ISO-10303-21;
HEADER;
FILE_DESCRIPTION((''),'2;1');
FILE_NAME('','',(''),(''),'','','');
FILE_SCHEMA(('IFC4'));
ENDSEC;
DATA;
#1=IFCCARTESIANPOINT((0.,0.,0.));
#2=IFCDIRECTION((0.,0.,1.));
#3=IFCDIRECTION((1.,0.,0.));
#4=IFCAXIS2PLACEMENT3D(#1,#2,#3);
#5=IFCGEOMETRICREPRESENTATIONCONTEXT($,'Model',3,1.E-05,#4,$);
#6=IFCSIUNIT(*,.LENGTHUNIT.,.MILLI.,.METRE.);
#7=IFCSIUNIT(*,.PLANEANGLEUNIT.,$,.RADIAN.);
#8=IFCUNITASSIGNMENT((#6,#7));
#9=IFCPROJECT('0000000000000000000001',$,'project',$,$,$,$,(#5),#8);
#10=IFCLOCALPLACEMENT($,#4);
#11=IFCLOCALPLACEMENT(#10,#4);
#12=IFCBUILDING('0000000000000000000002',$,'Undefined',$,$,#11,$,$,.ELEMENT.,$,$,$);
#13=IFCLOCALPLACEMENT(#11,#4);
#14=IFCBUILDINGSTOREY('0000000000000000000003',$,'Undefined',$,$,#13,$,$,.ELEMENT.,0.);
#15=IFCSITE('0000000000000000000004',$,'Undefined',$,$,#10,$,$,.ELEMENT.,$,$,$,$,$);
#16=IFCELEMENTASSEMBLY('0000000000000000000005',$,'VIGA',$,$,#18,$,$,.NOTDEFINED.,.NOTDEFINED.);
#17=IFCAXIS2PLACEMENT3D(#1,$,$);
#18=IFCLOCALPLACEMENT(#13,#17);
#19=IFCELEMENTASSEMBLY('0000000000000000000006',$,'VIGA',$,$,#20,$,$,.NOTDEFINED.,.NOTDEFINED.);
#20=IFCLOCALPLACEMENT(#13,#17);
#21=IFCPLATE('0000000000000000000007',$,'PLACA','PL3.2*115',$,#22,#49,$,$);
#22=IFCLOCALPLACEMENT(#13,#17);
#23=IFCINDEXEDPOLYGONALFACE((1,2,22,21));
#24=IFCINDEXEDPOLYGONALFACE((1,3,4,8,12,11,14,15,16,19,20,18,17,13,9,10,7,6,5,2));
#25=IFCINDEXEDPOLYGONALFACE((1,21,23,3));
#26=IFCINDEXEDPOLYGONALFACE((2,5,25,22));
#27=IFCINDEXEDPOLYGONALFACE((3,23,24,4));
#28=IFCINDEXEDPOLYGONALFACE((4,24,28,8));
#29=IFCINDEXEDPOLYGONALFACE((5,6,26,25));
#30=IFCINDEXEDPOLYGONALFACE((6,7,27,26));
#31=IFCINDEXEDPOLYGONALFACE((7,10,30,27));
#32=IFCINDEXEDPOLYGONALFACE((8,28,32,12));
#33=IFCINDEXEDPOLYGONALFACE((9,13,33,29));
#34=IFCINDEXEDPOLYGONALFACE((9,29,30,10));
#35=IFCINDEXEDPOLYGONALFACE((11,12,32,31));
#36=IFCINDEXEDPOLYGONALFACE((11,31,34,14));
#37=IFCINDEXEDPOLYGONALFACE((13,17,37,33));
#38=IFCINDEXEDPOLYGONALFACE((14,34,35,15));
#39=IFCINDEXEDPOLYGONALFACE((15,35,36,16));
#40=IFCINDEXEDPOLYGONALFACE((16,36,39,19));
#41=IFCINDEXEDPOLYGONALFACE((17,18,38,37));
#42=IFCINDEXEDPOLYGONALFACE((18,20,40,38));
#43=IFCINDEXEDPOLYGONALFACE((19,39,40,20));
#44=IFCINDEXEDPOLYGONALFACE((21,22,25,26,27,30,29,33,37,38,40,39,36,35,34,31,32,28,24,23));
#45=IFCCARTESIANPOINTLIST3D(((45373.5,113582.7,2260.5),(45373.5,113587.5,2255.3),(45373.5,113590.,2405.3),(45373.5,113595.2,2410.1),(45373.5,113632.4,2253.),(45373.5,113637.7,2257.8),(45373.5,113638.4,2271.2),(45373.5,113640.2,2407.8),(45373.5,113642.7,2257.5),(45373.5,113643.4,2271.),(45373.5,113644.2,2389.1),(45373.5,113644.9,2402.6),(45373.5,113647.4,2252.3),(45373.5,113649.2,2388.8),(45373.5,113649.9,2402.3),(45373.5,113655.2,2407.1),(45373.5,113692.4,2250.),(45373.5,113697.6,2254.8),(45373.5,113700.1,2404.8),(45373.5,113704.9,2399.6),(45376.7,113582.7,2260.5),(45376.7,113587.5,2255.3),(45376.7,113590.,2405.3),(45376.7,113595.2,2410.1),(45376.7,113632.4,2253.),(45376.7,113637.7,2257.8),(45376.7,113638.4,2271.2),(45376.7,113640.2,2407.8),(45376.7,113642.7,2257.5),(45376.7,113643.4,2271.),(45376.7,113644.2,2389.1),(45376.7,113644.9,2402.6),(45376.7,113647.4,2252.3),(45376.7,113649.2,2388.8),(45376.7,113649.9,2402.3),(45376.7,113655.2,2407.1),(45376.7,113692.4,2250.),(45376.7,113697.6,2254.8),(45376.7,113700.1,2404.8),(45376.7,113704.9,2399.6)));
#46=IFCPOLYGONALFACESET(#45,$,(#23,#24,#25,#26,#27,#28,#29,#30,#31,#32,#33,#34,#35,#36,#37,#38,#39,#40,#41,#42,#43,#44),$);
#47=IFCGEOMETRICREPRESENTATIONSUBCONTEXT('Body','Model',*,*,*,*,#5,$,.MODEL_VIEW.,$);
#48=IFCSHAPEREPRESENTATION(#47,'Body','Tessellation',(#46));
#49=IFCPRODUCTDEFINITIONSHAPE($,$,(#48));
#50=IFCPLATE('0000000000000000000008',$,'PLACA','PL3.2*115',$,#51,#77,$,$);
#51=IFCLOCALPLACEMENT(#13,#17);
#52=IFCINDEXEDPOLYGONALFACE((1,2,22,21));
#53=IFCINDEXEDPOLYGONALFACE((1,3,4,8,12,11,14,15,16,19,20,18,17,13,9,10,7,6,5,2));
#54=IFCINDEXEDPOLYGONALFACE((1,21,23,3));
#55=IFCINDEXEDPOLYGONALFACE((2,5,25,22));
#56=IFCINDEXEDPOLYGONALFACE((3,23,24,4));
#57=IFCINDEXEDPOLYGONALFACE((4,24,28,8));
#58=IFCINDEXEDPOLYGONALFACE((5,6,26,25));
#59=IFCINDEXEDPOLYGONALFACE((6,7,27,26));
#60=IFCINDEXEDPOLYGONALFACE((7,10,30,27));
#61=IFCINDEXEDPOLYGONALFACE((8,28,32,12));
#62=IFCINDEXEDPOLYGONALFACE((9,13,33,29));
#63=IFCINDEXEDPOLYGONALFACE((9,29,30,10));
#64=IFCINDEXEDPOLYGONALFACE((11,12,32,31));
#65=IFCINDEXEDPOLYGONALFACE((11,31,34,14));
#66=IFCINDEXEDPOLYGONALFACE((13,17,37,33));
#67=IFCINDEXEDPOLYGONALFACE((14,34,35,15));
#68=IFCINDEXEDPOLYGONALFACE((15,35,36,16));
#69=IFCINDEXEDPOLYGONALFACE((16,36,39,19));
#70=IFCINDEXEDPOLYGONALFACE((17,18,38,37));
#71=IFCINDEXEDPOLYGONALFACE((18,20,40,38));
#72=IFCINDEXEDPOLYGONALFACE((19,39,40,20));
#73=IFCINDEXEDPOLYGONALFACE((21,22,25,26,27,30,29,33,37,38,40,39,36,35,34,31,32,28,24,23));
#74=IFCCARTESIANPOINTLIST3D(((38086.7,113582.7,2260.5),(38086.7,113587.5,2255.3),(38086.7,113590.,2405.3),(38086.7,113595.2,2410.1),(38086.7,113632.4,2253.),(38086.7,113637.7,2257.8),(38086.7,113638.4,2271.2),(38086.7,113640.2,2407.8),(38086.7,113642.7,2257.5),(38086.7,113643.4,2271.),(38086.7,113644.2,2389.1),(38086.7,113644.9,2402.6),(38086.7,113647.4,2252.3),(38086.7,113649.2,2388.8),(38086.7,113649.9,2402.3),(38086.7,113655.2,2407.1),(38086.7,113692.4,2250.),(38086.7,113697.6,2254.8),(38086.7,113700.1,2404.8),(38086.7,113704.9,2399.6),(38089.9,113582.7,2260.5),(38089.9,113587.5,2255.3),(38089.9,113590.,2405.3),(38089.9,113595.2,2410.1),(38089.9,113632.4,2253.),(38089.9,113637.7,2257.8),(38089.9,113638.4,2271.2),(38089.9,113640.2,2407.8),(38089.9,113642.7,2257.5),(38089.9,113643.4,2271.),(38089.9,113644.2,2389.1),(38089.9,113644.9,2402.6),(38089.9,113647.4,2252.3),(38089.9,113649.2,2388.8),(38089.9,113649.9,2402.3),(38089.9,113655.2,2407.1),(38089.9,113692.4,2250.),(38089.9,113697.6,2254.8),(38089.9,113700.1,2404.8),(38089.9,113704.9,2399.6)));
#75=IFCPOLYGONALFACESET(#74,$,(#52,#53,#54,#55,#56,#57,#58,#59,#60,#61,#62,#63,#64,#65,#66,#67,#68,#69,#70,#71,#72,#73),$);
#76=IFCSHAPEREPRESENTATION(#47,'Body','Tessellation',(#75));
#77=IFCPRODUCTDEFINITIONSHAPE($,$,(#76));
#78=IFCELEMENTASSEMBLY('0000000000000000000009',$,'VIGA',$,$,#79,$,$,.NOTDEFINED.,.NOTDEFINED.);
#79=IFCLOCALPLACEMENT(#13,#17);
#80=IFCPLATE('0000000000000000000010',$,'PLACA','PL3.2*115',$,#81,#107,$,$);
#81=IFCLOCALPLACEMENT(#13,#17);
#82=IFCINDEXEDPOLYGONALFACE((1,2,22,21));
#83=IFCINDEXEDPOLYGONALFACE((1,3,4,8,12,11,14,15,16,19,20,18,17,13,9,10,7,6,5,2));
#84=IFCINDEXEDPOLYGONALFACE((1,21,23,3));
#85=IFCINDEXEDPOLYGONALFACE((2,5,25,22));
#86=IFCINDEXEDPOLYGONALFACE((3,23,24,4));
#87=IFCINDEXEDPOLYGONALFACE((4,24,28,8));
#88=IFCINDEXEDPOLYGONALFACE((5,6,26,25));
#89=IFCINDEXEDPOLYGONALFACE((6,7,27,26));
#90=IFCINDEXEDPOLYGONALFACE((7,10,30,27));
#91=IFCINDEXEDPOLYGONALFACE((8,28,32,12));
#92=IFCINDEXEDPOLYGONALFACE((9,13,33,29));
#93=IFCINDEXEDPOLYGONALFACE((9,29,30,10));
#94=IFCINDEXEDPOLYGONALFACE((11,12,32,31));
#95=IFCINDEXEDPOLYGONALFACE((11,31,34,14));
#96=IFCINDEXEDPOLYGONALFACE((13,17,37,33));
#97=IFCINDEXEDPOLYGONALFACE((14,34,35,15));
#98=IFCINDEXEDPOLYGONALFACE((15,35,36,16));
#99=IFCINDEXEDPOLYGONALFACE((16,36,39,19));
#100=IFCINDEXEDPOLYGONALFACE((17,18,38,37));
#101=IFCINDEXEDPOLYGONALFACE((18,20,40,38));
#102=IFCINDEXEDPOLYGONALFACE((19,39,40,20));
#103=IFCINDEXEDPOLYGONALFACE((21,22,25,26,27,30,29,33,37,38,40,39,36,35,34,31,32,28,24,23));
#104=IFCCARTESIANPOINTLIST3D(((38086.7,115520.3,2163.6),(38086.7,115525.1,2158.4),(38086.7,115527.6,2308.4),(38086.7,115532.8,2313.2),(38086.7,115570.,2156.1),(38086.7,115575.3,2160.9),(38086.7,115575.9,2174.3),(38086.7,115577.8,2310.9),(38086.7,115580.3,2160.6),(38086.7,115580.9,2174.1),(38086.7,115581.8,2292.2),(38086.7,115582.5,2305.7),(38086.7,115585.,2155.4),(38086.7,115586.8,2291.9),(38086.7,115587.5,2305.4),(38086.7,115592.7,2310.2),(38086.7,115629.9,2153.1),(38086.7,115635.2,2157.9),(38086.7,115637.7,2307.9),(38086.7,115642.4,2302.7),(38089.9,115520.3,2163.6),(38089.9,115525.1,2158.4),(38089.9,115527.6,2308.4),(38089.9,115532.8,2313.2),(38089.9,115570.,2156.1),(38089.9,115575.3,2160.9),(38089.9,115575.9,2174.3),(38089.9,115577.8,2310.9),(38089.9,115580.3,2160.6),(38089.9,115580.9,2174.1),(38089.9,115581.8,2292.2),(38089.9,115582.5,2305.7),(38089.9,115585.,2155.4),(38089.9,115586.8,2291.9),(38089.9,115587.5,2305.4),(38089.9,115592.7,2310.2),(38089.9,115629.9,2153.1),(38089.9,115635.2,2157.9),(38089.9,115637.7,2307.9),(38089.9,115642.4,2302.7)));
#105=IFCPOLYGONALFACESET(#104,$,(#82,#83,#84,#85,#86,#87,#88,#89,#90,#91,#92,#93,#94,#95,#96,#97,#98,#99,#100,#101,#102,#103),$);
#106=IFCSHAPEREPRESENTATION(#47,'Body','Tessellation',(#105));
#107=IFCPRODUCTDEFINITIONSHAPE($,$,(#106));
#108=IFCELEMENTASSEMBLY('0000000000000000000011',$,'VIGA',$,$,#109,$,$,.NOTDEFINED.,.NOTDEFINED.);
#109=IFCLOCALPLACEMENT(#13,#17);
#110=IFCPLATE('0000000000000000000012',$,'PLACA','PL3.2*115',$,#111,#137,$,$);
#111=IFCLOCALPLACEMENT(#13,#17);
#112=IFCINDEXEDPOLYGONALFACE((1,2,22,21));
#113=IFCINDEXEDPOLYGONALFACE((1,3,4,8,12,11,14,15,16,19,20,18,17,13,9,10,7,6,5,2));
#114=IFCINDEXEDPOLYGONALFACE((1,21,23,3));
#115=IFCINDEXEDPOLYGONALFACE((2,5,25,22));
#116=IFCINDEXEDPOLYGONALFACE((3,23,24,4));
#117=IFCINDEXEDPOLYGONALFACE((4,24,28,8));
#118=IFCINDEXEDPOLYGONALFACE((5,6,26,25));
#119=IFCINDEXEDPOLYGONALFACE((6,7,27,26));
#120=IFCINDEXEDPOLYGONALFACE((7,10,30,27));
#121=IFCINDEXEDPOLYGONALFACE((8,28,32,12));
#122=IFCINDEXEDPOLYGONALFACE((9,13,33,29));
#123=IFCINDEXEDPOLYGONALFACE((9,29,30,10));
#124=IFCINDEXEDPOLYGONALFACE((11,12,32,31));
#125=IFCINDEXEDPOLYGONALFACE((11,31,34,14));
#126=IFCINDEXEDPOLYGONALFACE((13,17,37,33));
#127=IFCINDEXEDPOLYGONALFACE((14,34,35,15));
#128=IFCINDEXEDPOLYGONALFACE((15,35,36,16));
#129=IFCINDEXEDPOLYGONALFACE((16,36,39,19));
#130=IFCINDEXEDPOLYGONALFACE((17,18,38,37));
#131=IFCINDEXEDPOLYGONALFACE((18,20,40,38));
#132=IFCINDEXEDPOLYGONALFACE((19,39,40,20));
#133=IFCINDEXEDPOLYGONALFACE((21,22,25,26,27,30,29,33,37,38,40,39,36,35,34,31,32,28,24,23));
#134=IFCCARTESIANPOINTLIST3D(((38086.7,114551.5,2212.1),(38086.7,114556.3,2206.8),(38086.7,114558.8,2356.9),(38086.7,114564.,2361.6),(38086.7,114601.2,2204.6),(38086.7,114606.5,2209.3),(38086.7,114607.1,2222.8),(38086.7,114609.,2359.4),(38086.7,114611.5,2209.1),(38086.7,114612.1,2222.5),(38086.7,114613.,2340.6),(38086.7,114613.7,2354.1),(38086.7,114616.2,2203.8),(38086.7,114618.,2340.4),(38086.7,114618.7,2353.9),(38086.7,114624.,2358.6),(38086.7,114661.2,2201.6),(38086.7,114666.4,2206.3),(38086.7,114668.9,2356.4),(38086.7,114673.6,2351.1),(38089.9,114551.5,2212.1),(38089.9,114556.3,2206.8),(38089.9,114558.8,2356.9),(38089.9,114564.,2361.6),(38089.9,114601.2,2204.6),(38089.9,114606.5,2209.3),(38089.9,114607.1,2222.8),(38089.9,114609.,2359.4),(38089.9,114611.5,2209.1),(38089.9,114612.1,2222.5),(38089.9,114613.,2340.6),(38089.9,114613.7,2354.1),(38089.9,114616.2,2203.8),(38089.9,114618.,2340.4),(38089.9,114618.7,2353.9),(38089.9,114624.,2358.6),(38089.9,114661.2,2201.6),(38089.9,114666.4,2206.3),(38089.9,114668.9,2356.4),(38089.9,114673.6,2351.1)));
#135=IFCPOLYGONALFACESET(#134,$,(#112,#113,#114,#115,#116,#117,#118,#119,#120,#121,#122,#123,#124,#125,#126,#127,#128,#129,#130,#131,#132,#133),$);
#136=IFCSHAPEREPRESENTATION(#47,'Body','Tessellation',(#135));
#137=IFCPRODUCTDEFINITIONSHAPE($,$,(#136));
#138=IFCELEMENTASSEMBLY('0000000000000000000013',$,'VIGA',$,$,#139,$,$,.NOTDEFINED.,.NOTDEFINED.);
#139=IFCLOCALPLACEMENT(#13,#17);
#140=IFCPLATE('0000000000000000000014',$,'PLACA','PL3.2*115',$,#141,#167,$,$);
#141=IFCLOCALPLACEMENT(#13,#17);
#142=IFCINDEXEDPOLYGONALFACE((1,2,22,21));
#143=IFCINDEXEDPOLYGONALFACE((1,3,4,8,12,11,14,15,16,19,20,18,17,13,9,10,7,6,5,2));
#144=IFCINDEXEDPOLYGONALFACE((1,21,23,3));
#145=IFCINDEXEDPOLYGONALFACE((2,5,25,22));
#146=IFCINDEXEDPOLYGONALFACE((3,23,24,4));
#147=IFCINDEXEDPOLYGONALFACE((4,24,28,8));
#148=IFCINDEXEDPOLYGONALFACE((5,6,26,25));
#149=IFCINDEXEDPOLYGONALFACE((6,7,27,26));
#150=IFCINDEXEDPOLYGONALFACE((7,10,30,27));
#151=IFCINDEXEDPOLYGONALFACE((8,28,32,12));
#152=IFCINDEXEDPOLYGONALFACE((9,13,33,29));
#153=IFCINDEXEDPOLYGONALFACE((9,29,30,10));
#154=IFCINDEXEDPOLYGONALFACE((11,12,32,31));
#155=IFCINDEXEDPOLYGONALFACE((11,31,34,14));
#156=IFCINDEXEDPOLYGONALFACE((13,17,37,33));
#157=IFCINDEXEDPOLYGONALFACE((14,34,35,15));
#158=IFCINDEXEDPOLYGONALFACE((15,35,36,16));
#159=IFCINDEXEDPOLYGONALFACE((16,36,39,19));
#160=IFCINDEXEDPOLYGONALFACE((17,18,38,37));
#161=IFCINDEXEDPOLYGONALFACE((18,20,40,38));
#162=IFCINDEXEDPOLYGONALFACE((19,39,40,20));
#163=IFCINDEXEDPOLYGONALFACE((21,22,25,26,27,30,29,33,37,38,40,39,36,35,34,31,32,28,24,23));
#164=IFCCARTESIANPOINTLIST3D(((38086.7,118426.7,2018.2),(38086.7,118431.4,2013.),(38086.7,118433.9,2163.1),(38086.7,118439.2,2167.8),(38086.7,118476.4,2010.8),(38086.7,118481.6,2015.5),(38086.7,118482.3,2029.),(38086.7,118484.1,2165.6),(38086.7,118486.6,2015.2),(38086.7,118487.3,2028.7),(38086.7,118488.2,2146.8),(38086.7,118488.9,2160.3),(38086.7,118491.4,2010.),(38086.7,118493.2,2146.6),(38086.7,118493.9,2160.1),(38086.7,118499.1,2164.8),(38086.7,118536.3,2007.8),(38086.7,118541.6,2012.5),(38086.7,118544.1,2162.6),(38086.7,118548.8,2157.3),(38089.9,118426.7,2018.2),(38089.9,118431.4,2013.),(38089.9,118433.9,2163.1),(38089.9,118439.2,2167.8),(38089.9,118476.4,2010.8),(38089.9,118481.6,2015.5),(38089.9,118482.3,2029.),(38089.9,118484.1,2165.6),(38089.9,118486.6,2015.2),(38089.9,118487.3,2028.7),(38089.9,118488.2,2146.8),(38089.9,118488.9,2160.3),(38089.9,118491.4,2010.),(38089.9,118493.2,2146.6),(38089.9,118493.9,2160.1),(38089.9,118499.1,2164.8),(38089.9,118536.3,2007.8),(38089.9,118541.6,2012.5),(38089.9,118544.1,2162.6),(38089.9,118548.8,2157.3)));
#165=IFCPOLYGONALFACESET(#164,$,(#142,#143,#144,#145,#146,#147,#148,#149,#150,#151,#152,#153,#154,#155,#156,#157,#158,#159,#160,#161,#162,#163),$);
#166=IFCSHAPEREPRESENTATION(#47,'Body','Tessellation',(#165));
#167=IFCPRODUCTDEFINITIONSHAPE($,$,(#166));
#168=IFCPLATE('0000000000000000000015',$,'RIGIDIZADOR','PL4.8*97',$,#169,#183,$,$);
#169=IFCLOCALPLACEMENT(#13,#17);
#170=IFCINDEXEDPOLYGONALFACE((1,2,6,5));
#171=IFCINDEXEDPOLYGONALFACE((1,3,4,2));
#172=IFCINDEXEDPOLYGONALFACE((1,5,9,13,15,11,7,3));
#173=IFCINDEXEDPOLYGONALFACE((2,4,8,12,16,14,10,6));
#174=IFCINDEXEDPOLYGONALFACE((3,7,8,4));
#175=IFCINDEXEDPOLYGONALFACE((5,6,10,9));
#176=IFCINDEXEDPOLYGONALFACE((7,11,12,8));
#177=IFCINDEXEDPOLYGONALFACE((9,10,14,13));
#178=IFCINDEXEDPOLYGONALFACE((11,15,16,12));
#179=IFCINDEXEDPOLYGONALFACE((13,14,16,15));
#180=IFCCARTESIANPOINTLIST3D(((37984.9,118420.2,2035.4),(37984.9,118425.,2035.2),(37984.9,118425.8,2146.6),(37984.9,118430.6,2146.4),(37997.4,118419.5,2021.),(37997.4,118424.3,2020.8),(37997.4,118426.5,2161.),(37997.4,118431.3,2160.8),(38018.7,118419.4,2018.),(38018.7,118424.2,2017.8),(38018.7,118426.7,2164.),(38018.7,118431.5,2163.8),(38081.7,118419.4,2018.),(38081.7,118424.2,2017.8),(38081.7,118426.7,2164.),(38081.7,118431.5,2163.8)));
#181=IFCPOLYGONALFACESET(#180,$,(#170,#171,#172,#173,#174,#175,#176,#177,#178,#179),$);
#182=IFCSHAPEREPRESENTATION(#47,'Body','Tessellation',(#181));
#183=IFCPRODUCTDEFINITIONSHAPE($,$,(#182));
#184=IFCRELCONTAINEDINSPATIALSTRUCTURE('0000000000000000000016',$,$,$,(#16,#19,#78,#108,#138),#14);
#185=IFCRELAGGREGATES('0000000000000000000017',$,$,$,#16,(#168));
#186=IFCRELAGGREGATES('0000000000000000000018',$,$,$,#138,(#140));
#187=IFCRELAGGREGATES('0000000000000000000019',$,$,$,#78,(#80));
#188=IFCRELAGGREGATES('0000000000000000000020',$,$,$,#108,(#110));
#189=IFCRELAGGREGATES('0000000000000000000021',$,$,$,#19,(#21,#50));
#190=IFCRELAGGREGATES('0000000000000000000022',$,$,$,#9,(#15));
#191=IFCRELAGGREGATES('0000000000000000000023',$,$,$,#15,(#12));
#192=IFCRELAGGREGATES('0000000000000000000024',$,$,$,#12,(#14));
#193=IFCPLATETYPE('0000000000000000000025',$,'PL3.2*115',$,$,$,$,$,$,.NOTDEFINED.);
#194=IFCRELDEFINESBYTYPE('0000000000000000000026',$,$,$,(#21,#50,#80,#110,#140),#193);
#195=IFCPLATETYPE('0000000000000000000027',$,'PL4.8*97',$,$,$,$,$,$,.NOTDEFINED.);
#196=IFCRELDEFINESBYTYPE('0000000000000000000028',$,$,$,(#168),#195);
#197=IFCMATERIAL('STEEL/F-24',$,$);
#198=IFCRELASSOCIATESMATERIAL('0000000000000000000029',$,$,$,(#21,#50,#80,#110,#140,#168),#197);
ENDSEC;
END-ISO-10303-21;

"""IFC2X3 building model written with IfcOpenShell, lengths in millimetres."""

from ifc_helpers import new_model, si_unit, frame, origin_with_axes, place, context, subcontext, project, spatial, polyline, outline, extrude, material, type_object, element, aggregate, save


model = new_model("IFC2X3")

# Units and contexts
model_context = context("Model", 3, precision=1e-05, world=origin_with_axes())
body_context = subcontext(model_context, "Body", "Model", "MODEL_VIEW")
ifc_project = project(units=[si_unit("LENGTHUNIT", "METRE", prefix="MILLI"), si_unit("PLANEANGLEUNIT", "RADIAN")], contexts=[model_context])

# Site, building, storey
site_placement = place(None, origin_with_axes())
site = spatial("IfcSite", under=ifc_project, at=site_placement, Name="Undefined", CompositionType="ELEMENT")
building_placement = place(site_placement, origin_with_axes())
building = spatial("IfcBuilding", under=site, at=building_placement, Name="Undefined", CompositionType="ELEMENT")
storey_placement = place(building_placement, origin_with_axes())
storey = spatial("IfcBuildingStorey", under=building, at=storey_placement, Name="Undefined", CompositionType="ELEMENT", Elevation=0.0)

# Element assembly
assembly_1_placement = place(storey_placement, origin_with_axes())
assembly_1 = element("IfcElementAssembly", 1, at=assembly_1_placement, inside=storey, Name="VIGA", AssemblyPlace="NOTDEFINED", PredefinedType="NOTDEFINED")
ifc_material_1 = material(Name="STEEL/F-24")

# Shared definitions
plate_type_1 = type_object("IfcPlateType", Name="PL3.2*115", PredefinedType="NOTDEFINED")

# Element assembly, plates
assembly_2_placement = place(storey_placement, origin_with_axes())
assembly_2 = element("IfcElementAssembly", 2, at=assembly_2_placement, inside=storey, Name="VIGA", AssemblyPlace="NOTDEFINED", PredefinedType="NOTDEFINED")
plate_1_placement = place(assembly_2_placement, frame((45375.1, 113705.1, 2404.6), z_axis=(1.0, 0.0, 0.0), x_axis=(0.0, -0.998752, 0.04995)))
plate_1 = element("IfcPlate", 3, at=plate_1_placement, type_object=plate_type_1, material=ifc_material_1, Name="PLACA", Description="PL3.2*115", context=body_context, shape_type="SweptSolid", body=[
    extrude(outline(polyline([(0.0, 5.0), (5.0, 0.0), (50.0, 0.0), (55.0, 5.0), (55.0, 18.5), (60.0, 18.5), (60.0, 5.0), (65.0, 0.0), (110.0, 0.0), (115.0, 5.0), (115.0, 150.0), (110.0, 155.0), (65.0, 155.0), (60.0, 150.0), (60.0, 136.5), (55.0, 136.5), (55.0, 150.0), (50.0, 155.0), (5.0, 155.0), (0.0, 150.0), (0.0, 5.0)])), frame((0.0, 0.0, -1.6), z_axis=(0.0, 0.0, 1.0), x_axis=(1.0, 0.0, 0.0)), (0.0, 0.0, 1.0), 3.2),
])
plate_2_placement = place(assembly_2_placement, frame((38088.3, 113705.1, 2404.6), z_axis=(1.0, 0.0, 0.0), x_axis=(0.0, -0.998752, 0.04995)))
plate_2 = element("IfcPlate", 4, at=plate_2_placement, type_object=plate_type_1, material=ifc_material_1, Name="PLACA", Description="PL3.2*115", context=body_context, shape_type="SweptSolid", body=[
    extrude(outline(polyline([(0.0, 5.0), (5.0, 0.0), (50.0, 0.0), (55.0, 5.0), (55.0, 18.5), (60.0, 18.5), (60.0, 5.0), (65.0, 0.0), (110.0, 0.0), (115.0, 5.0), (115.0, 150.0), (110.0, 155.0), (65.0, 155.0), (60.0, 150.0), (60.0, 136.5), (55.0, 136.5), (55.0, 150.0), (50.0, 155.0), (5.0, 155.0), (0.0, 150.0), (0.0, 5.0)])), frame((0.0, 0.0, -1.6), z_axis=(0.0, 0.0, 1.0), x_axis=(1.0, 0.0, 0.0)), (0.0, 0.0, 1.0), 3.2),
])

# Element assemblies, plates
assembly_3_placement = place(storey_placement, origin_with_axes())
assembly_3 = element("IfcElementAssembly", 5, at=assembly_3_placement, inside=storey, Name="VIGA", AssemblyPlace="NOTDEFINED", PredefinedType="NOTDEFINED")
plate_3_placement = place(assembly_3_placement, frame((38088.3, 115642.7, 2307.7), z_axis=(1.0, 0.0, 0.0), x_axis=(0.0, -0.998752, 0.04995)))
plate_3 = element("IfcPlate", 6, at=plate_3_placement, type_object=plate_type_1, material=ifc_material_1, Name="PLACA", Description="PL3.2*115", context=body_context, shape_type="SweptSolid", body=[
    extrude(outline(polyline([(0.0, 5.0), (5.0, 0.0), (50.0, 0.0), (55.0, 5.0), (55.0, 18.5), (60.0, 18.5), (60.0, 5.0), (65.0, 0.0), (110.0, 0.0), (115.0, 5.0), (115.0, 150.0), (110.0, 155.0), (65.0, 155.0), (60.0, 150.0), (60.0, 136.5), (55.0, 136.5), (55.0, 150.0), (50.0, 155.0), (5.0, 155.0), (0.0, 150.0), (0.0, 5.0)])), frame((0.0, 0.0, -1.6), z_axis=(0.0, 0.0, 1.0), x_axis=(1.0, 0.0, 0.0)), (0.0, 0.0, 1.0), 3.2),
])
assembly_4_placement = place(storey_placement, origin_with_axes())
assembly_4 = element("IfcElementAssembly", 7, at=assembly_4_placement, inside=storey, Name="VIGA", AssemblyPlace="NOTDEFINED", PredefinedType="NOTDEFINED")
plate_4_placement = place(assembly_4_placement, frame((38088.3, 114673.9, 2356.1), z_axis=(1.0, 0.0, 0.0), x_axis=(0.0, -0.998752, 0.04995)))
plate_4 = element("IfcPlate", 8, at=plate_4_placement, type_object=plate_type_1, material=ifc_material_1, Name="PLACA", Description="PL3.2*115", context=body_context, shape_type="SweptSolid", body=[
    extrude(outline(polyline([(0.0, 5.0), (5.0, 0.0), (50.0, 0.0), (55.0, 5.0), (55.0, 18.5), (60.0, 18.5), (60.0, 5.0), (65.0, 0.0), (110.0, 0.0), (115.0, 5.0), (115.0, 150.0), (110.0, 155.0), (65.0, 155.0), (60.0, 150.0), (60.0, 136.5), (55.0, 136.5), (55.0, 150.0), (50.0, 155.0), (5.0, 155.0), (0.0, 150.0), (0.0, 5.0)])), frame((0.0, 0.0, -1.6), z_axis=(0.0, 0.0, 1.0), x_axis=(1.0, 0.0, 0.0)), (0.0, 0.0, 1.0), 3.2),
])
assembly_5_placement = place(storey_placement, origin_with_axes())
assembly_5 = element("IfcElementAssembly", 9, at=assembly_5_placement, inside=storey, Name="VIGA", AssemblyPlace="NOTDEFINED", PredefinedType="NOTDEFINED")
plate_5_placement = place(assembly_5_placement, frame((38088.3, 118549.0, 2162.3), z_axis=(1.0, 0.0, 0.0), x_axis=(0.0, -0.998752, 0.04995)))
plate_5 = element("IfcPlate", 10, at=plate_5_placement, type_object=plate_type_1, material=ifc_material_1, Name="PLACA", Description="PL3.2*115", context=body_context, shape_type="SweptSolid", body=[
    extrude(outline(polyline([(0.0, 5.0), (5.0, 0.0), (50.0, 0.0), (55.0, 5.0), (55.0, 18.5), (60.0, 18.5), (60.0, 5.0), (65.0, 0.0), (110.0, 0.0), (115.0, 5.0), (115.0, 150.0), (110.0, 155.0), (65.0, 155.0), (60.0, 150.0), (60.0, 136.5), (55.0, 136.5), (55.0, 150.0), (50.0, 155.0), (5.0, 155.0), (0.0, 150.0), (0.0, 5.0)])), frame((0.0, 0.0, -1.6), z_axis=(0.0, 0.0, 1.0), x_axis=(1.0, 0.0, 0.0)), (0.0, 0.0, 1.0), 3.2),
])

# Plate
plate_type_2 = type_object("IfcPlateType", Name="PL4.8*97", PredefinedType="NOTDEFINED")
plate_6_placement = place(assembly_1_placement, frame((38081.7, 118429.1, 2163.9), z_axis=(0.0, -0.998752, 0.04995), x_axis=(-1.0, 0.0, 0.0)))
plate_6 = element("IfcPlate", 11, at=plate_6_placement, type_object=plate_type_2, material=ifc_material_1, Name="RIGIDIZADOR", Description="PL4.8*97", context=body_context, shape_type="SweptSolid", body=[
    extrude(outline(polyline([(0.0, 0.0), (63.0, 0.0), (84.3, 3.0), (96.8, 17.4), (96.8, 128.7), (84.3, 143.2), (63.0, 146.2), (0.0, 146.2), (0.0, 0.0)])), frame((0.0, 0.0, -2.4), z_axis=(0.0, 0.0, 1.0), x_axis=(1.0, 0.0, 0.0)), (0.0, 0.0, 1.0), 4.8),
])
aggregate(assembly_1, [plate_6])

aggregate(assembly_5, [plate_5])
aggregate(assembly_3, [plate_3])
aggregate(assembly_4, [plate_4])
aggregate(assembly_2, [plate_1, plate_2])

save(model, "model.ifc")
